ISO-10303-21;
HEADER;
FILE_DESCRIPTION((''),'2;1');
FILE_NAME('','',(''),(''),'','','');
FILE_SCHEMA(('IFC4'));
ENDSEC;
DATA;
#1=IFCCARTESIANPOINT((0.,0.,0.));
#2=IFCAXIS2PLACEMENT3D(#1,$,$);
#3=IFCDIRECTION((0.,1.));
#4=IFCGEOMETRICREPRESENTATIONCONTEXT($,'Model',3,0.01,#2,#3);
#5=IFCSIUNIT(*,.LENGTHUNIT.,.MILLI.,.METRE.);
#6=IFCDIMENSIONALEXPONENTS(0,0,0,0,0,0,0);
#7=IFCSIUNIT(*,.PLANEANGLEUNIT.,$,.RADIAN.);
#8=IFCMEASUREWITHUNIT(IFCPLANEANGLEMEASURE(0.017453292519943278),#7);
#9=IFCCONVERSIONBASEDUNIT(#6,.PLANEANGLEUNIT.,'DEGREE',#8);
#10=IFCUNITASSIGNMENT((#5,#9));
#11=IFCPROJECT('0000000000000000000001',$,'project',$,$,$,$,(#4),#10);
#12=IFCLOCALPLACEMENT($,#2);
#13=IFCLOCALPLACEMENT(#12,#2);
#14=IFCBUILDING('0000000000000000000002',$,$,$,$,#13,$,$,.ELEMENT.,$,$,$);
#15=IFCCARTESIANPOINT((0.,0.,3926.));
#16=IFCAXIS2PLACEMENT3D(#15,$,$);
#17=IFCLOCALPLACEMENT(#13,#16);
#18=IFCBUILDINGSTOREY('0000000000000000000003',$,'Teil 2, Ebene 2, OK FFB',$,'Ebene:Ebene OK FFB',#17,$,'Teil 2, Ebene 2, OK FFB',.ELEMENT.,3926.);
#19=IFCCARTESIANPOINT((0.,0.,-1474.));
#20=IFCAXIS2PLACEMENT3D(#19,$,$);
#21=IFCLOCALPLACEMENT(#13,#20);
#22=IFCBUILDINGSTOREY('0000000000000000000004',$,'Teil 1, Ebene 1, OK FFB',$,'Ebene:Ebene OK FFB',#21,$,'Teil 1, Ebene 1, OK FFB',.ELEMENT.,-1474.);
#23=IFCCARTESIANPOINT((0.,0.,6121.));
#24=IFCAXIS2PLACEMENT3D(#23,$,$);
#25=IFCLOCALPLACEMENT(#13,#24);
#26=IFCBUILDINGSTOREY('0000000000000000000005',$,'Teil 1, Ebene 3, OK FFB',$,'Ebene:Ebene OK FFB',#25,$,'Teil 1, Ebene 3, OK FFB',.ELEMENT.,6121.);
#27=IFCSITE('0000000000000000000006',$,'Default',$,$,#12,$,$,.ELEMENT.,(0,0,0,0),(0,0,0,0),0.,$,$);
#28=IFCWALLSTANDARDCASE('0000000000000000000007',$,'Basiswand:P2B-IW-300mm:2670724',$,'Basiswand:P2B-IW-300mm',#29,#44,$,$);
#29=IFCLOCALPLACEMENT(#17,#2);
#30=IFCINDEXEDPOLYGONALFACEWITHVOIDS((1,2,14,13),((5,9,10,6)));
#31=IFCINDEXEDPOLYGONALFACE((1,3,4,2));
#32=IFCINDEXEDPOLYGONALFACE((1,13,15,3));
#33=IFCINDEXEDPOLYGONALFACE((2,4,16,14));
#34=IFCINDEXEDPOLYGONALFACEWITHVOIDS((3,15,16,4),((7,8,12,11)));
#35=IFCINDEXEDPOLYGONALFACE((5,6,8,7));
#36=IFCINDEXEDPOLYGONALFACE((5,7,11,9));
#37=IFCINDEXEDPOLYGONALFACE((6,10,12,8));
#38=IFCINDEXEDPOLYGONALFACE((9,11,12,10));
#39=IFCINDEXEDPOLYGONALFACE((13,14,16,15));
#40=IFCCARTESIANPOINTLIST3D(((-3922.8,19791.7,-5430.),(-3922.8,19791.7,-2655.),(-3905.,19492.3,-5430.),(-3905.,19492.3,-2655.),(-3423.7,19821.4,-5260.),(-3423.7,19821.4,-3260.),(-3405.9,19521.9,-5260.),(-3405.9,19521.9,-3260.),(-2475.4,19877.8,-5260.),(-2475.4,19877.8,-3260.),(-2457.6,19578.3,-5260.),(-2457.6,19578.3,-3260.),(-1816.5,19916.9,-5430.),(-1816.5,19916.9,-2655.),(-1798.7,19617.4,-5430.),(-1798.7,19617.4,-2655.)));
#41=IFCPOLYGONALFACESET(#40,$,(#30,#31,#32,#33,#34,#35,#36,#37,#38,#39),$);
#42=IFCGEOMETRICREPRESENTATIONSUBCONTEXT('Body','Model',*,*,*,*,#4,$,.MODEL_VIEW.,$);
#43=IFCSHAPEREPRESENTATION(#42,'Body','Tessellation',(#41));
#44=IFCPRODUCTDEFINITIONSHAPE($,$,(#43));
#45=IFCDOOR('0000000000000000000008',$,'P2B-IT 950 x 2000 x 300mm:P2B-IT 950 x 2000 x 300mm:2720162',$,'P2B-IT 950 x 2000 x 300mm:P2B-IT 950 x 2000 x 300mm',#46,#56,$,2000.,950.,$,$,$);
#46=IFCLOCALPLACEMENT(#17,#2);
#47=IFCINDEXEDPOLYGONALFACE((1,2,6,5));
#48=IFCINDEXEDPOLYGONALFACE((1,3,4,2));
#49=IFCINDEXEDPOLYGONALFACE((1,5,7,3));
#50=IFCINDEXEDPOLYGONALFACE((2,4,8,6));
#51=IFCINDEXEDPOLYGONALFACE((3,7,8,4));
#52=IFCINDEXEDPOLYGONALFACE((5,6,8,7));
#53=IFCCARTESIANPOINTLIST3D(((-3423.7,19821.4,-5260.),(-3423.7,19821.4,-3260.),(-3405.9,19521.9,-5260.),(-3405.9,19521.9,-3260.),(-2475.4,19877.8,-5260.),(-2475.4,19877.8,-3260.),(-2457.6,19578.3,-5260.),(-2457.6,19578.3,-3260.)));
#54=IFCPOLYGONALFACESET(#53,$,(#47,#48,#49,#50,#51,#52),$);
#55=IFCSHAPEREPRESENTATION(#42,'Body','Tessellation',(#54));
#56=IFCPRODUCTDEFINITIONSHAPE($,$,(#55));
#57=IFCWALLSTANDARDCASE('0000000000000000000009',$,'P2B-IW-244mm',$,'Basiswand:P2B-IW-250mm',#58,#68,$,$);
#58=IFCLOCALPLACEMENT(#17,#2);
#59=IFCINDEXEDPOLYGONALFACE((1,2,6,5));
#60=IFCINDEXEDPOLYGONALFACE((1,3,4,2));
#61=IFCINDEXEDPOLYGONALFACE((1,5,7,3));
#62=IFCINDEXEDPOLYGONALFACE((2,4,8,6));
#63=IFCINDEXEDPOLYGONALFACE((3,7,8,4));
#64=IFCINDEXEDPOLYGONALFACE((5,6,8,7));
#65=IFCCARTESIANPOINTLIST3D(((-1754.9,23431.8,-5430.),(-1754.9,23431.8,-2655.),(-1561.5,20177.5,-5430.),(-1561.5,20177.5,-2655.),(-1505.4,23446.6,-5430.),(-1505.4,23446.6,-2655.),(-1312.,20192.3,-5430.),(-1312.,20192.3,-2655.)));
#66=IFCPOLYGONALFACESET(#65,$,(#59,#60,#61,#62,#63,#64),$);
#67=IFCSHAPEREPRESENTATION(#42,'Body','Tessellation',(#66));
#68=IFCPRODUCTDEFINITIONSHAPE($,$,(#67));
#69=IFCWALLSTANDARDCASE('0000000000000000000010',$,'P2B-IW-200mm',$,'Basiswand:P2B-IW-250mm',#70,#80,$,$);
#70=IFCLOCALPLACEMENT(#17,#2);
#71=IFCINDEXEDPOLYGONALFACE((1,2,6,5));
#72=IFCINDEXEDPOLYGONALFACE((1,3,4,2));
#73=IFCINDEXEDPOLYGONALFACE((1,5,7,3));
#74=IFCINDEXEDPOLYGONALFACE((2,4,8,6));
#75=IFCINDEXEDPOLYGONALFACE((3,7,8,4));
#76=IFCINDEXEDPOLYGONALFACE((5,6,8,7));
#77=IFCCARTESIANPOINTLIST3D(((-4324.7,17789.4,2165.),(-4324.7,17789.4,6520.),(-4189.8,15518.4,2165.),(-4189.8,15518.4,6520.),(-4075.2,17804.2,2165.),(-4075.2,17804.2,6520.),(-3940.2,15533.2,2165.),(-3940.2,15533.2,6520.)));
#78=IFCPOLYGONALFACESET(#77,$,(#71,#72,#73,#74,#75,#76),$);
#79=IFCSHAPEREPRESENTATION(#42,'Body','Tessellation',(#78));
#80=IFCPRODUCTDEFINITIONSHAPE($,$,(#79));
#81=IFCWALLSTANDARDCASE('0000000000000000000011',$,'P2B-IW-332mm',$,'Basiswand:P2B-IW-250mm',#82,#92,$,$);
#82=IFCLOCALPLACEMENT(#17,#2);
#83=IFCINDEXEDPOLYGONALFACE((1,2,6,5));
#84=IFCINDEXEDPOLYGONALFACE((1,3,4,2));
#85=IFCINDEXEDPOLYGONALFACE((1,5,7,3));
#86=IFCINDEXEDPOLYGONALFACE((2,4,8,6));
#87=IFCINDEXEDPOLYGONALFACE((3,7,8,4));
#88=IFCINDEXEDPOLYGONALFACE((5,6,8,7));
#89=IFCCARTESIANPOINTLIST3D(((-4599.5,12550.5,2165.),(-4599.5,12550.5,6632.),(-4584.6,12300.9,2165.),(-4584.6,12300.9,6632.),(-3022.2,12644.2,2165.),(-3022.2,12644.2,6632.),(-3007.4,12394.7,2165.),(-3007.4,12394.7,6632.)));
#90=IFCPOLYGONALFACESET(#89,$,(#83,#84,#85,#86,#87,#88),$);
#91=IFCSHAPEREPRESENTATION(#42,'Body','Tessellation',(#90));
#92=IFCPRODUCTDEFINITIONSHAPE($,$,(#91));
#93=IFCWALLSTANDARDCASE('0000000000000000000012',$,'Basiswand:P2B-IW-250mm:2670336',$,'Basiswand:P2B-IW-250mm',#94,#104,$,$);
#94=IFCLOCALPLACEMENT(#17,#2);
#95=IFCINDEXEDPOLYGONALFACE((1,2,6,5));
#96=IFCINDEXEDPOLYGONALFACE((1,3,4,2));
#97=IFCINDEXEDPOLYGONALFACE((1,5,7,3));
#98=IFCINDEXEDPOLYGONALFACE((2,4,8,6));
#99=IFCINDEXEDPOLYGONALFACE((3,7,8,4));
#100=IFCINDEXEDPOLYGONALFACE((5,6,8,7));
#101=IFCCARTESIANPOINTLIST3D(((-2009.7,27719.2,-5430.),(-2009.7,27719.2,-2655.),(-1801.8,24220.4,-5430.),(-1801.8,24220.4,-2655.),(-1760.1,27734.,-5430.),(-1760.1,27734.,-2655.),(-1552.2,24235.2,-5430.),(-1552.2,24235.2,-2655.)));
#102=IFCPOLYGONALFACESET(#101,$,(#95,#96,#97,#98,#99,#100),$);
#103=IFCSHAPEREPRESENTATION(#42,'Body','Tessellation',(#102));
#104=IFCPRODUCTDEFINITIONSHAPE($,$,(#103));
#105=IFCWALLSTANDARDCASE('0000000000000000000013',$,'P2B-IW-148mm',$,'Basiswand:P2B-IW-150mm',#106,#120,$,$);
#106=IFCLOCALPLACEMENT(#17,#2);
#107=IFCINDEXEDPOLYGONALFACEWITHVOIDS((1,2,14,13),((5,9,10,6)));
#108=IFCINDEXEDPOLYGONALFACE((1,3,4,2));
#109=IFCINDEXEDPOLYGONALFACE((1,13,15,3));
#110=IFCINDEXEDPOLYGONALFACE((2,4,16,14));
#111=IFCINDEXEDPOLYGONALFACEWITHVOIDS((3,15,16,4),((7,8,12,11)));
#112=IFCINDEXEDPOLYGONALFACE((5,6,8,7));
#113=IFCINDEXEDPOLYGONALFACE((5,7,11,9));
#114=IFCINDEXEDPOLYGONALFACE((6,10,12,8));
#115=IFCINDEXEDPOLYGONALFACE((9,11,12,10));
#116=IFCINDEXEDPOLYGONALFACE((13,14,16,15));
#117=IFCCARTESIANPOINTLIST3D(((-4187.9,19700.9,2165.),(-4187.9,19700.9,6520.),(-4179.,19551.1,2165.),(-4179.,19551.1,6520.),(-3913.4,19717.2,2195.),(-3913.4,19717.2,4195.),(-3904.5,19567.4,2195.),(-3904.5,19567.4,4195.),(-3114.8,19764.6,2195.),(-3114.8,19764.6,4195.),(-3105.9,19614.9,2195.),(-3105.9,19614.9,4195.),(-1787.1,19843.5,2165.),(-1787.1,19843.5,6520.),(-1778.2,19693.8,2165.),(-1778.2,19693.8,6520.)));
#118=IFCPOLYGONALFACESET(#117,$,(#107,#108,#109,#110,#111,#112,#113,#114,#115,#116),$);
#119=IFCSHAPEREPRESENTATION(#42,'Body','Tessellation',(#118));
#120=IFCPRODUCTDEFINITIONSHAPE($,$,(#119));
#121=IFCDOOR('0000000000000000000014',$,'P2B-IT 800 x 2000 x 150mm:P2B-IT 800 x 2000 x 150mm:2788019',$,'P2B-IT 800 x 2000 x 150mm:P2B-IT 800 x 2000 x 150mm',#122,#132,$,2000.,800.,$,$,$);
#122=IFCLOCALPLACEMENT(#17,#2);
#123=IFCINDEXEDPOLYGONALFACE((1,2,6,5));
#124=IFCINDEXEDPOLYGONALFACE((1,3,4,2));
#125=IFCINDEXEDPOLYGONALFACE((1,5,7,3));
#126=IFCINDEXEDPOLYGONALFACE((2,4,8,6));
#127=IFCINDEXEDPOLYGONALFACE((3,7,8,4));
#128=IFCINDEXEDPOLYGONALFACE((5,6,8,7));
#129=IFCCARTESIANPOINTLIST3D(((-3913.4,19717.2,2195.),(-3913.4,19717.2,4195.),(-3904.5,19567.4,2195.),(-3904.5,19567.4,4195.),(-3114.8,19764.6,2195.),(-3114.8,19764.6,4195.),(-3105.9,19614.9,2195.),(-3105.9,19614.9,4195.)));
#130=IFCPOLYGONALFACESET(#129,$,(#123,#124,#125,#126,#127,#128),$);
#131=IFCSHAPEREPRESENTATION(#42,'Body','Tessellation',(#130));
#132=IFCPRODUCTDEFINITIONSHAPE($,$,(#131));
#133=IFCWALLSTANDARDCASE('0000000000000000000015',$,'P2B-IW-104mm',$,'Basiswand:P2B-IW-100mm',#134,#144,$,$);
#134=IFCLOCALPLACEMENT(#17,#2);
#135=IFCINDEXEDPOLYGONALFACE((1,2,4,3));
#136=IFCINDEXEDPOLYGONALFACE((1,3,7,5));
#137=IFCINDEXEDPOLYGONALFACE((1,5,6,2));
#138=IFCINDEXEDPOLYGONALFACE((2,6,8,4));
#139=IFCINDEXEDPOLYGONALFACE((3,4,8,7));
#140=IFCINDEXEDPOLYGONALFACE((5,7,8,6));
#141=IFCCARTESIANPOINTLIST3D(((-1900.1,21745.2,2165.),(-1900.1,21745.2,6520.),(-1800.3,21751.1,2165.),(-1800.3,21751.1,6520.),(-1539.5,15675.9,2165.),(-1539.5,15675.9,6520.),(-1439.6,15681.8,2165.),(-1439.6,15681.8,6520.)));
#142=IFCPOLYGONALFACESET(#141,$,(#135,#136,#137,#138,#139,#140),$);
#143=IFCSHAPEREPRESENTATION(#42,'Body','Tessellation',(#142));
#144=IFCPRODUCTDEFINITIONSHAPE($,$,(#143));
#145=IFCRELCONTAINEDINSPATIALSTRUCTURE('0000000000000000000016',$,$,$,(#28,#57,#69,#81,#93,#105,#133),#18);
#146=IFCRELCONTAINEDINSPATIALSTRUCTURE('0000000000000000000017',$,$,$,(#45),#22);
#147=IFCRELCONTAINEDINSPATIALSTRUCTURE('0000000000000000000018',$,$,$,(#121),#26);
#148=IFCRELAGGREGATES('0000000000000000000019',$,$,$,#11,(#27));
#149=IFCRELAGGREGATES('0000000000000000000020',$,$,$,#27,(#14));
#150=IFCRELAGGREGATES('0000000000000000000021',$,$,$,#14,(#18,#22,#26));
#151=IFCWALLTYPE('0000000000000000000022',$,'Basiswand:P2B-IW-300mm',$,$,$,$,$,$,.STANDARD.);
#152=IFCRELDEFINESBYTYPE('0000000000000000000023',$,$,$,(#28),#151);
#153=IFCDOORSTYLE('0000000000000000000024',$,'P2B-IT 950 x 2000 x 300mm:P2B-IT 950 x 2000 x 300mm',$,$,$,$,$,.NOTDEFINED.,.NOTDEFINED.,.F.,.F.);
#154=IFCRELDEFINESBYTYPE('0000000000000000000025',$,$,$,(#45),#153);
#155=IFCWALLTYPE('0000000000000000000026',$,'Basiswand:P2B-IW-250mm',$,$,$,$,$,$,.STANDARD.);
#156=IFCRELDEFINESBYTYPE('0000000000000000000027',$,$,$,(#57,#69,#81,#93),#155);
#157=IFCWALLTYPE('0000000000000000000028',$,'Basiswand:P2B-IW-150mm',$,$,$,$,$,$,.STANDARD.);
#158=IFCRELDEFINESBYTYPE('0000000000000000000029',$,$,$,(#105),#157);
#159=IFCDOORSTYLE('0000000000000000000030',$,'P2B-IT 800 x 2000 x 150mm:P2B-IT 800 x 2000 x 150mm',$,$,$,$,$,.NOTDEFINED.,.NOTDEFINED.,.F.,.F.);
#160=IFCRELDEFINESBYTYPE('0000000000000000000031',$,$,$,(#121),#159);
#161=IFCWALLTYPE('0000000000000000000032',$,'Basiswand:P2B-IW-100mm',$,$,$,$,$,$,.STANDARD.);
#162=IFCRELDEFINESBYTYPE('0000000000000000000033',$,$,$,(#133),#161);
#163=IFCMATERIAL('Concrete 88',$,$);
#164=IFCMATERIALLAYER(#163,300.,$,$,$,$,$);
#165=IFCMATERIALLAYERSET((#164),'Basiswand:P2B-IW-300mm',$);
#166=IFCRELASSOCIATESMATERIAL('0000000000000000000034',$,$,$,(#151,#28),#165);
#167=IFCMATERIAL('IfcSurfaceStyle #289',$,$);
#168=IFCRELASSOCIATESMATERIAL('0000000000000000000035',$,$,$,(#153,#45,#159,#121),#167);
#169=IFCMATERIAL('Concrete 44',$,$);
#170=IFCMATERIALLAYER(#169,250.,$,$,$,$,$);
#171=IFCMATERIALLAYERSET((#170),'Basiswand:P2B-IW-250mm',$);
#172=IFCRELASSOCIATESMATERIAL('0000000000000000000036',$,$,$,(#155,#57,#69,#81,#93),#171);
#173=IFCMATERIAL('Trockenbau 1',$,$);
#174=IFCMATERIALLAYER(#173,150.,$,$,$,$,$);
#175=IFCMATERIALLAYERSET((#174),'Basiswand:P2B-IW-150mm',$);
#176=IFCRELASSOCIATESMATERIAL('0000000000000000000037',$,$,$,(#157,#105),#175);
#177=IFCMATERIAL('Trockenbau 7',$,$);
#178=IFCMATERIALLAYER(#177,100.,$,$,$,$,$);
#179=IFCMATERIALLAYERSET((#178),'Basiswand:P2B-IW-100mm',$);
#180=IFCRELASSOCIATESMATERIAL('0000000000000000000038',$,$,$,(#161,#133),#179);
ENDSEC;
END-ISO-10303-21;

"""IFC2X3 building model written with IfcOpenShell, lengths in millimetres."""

from ifc_helpers import new_model, entity, si_unit, converted_unit, direction, frame, frame_2d, origin, origin_2d_with_axis, place, context, subcontext, project, spatial, rectangle, extrude, source, transform, mapped, material, layer, layer_set, layer_usage, type_object, type_shapes, element, fill, save


model = new_model("IFC2X3")

# Units and contexts
model_context = context("Model", 3, precision=0.01, world=origin(), true_north=direction((0.0, 1.0)))
body_context = subcontext(model_context, "Body", "Model", "MODEL_VIEW")
ifc_project = project(units=[si_unit("LENGTHUNIT", "METRE", prefix="MILLI"), converted_unit("PLANEANGLEUNIT", "DEGREE", entity("IfcPlaneAngleMeasure", 0.017453292519943278), si_unit("PLANEANGLEUNIT", "RADIAN"), dimensions=[0, 0, 0, 0, 0, 0, 0])], contexts=[model_context])

# Site, building, storey
site_placement = place(None, origin())
site = spatial("IfcSite", under=ifc_project, at=site_placement, Name="Default", CompositionType="ELEMENT", RefLatitude=(0, 0, 0, 0), RefLongitude=(0, 0, 0, 0), RefElevation=0.0)
building_placement = place(site_placement, origin())
building = spatial("IfcBuilding", under=site, at=building_placement, CompositionType="ELEMENT")
storey_1_placement = place(building_placement, frame((0.0, 0.0, 3926.0)))
storey_1 = spatial("IfcBuildingStorey", under=building, at=storey_1_placement, Name="Teil 2, Ebene 2, OK FFB", ObjectType="Ebene:Ebene OK FFB", LongName="Teil 2, Ebene 2, OK FFB", CompositionType="ELEMENT", Elevation=3926.0)

# Wall, opening
ifc_material_1 = material(Name="Concrete 88")
ifc_layer_1 = layer(ifc_material_1, 300.0)
ifc_layer_set_1 = layer_set([ifc_layer_1], Name="Basiswand:P2B-IW-300mm")
ifc_layer_usage_1 = layer_usage(ifc_layer_set_1, "AXIS2", "NEGATIVE", 150.0)
wall_type_1 = type_object("IfcWallType", Name="Basiswand:P2B-IW-300mm", PredefinedType="STANDARD", material=ifc_layer_set_1)
wall_1_placement = place(storey_1_placement, frame((-1807.6, 19767.2, -5430.0), z_axis=(0.0, 0.0, 1.0), x_axis=(-0.998239, -0.059319, 0.0)))
wall_1 = element("IfcWallStandardCase", 1, at=wall_1_placement, inside=storey_1, type_object=wall_type_1, material=ifc_layer_usage_1, Name="Basiswand:P2B-IW-300mm:2670724", ObjectType="Basiswand:P2B-IW-300mm", context=body_context, shape_type="SweptSolid", body=[
    extrude(rectangle(XDim=2110.0, YDim=300.0, at=frame_2d((1055.0, 0.0), x_axis=(-1.0, 0.0))), origin(), (0.0, 0.0, 1.0), 2775.0),
])
opening_1_placement = place(wall_1_placement, frame((-631.9, 19839.6, 30.0), z_axis=(0.0, 0.0, 1.0), x_axis=(-0.998239, 0.059319, 0.0)))
opening_1 = element("IfcOpeningElement", 2, at=opening_1_placement, cuts=wall_1, ObjectType="Opening", context=body_context, shape_type="SweptSolid", body=[
    extrude(rectangle(XDim=2000.0, YDim=950.0, at=frame_2d((0.0, 0.0), x_axis=(1.0, 0.0))), frame((-2949.5, 19849.6, 1140.0), z_axis=(0.059319, -0.998239, 0.0), x_axis=(0.0, 0.0, -1.0)), (0.0, 0.0, 1.0), 300.0),
])

# Shared definitions
storey_2_placement = place(building_placement, frame((0.0, 0.0, -1474.0)))
storey_2 = spatial("IfcBuildingStorey", under=building, at=storey_2_placement, Name="Teil 1, Ebene 1, OK FFB", ObjectType="Ebene:Ebene OK FFB", LongName="Teil 1, Ebene 1, OK FFB", CompositionType="ELEMENT", Elevation=-1474.0)

# Door
ifc_material_2 = material(Name="IfcSurfaceStyle #289")
door_style_1 = type_object("IfcDoorStyle", Name="P2B-IT 950 x 2000 x 300mm:P2B-IT 950 x 2000 x 300mm", ConstructionType="NOTDEFINED", OperationType="NOTDEFINED", ParameterTakesPrecedence=False, Sizeable=False, material=ifc_material_2)
shared_shape_1 = source(origin(), body_context, "Body", "SweptSolid", [
    extrude(rectangle(XDim=300.0, YDim=950.0, at=frame_2d((0.0, 0.0), x_axis=(1.0, 0.0))), frame((475.0, 150.0, 0.0), z_axis=(0.0, 0.0, 1.0), x_axis=(0.0, 1.0, 0.0)), (0.0, 0.0, 1.0), 2000.0),
])
type_shapes(door_style_1, [shared_shape_1])
door_1_placement = place(opening_1_placement, frame((-3405.9, 19521.9, 140.0), z_axis=(0.0, 0.0, 1.0), x_axis=(0.998239, 0.059319, 0.0)))
door_1 = element("IfcDoor", 3, at=door_1_placement, inside=storey_2, type_object=door_style_1, material=ifc_material_2, Name="P2B-IT 950 x 2000 x 300mm:P2B-IT 950 x 2000 x 300mm:2720162", ObjectType="P2B-IT 950 x 2000 x 300mm:P2B-IT 950 x 2000 x 300mm", OverallHeight=2000.0, OverallWidth=950.0, context=body_context, shape_type="MappedRepresentation", body=[
    mapped(shared_shape_1, transform((0.0, 0.0, 0.0), scale=1.0)),
])
fill(opening_1, door_1)

# Wall
ifc_material_3 = material(Name="Concrete 44")
ifc_layer_2 = layer(ifc_material_3, 250.0)
ifc_layer_set_2 = layer_set([ifc_layer_2], Name="Basiswand:P2B-IW-250mm")
ifc_layer_usage_2 = layer_usage(ifc_layer_set_2, "AXIS2", "NEGATIVE", 125.0)
wall_type_2 = type_object("IfcWallType", Name="Basiswand:P2B-IW-250mm", PredefinedType="STANDARD", material=ifc_layer_set_2)
wall_2_placement = place(storey_1_placement, frame((-1436.8, 20184.9, -5430.0), z_axis=(0.0, 0.0, 1.0), x_axis=(-0.059319, 0.998239, 0.0)))
element("IfcWallStandardCase", 4, at=wall_2_placement, inside=storey_1, type_object=wall_type_2, material=ifc_layer_usage_2, Name="P2B-IW-244mm", ObjectType="Basiswand:P2B-IW-250mm", context=body_context, shape_type="SweptSolid", body=[
    extrude(rectangle(XDim=3260.0, YDim=250.0, at=frame_2d((1630.0, 0.0), x_axis=(-1.0, 0.0))), origin(), (0.0, 0.0, 1.0), 2775.0),
])

# Walls
ifc_layer_usage_3 = layer_usage(ifc_layer_set_2, "AXIS2", "POSITIVE", -125.0)
wall_3_placement = place(storey_1_placement, frame((-4065.0, 15525.8, 2165.0), z_axis=(0.0, 0.0, 1.0), x_axis=(-0.059319, 0.998239, 0.0)))
element("IfcWallStandardCase", 5, at=wall_3_placement, inside=storey_1, type_object=wall_type_2, material=ifc_layer_usage_3, Name="P2B-IW-200mm", ObjectType="Basiswand:P2B-IW-250mm", context=body_context, shape_type="SweptSolid", body=[
    extrude(rectangle(XDim=2275.0, YDim=250.0, at=frame_2d((1137.5, 0.0), x_axis=(-1.0, 0.0))), origin(), (0.0, 0.0, 1.0), 4355.0),
])
ifc_layer_usage_4 = layer_usage(ifc_layer_set_2, "AXIS2", "POSITIVE", -125.0)
wall_4_placement = place(storey_1_placement, frame((-3014.8, 12519.5, 2165.0), z_axis=(0.0, 0.0, 1.0), x_axis=(-0.998239, -0.059319, 0.0)))
element("IfcWallStandardCase", 6, at=wall_4_placement, inside=storey_1, type_object=wall_type_2, material=ifc_layer_usage_4, Name="P2B-IW-332mm", ObjectType="Basiswand:P2B-IW-250mm", context=body_context, shape_type="SweptSolid", body=[
    extrude(rectangle(XDim=1580.0, YDim=250.0, at=frame_2d((790.0, 0.0), x_axis=(-1.0, 0.0))), origin(), (0.0, 0.0, 1.0), 4467.0),
])
ifc_layer_usage_5 = layer_usage(ifc_layer_set_2, "AXIS2", "NEGATIVE", 125.0)
wall_5_placement = place(storey_1_placement, frame((-1677.0, 24227.8, -5430.0), z_axis=(0.0, 0.0, 1.0), x_axis=(-0.059319, 0.998239, 0.0)))
element("IfcWallStandardCase", 7, at=wall_5_placement, inside=storey_1, type_object=wall_type_2, material=ifc_layer_usage_5, Name="Basiswand:P2B-IW-250mm:2670336", ObjectType="Basiswand:P2B-IW-250mm", context=body_context, shape_type="SweptSolid", body=[
    extrude(rectangle(XDim=3505.0, YDim=250.0, at=frame_2d((1752.5, 0.0), x_axis=(-1.0, 0.0))), origin(), (0.0, 0.0, 1.0), 2775.0),
])

# Wall, opening
ifc_material_4 = material(Name="Trockenbau 1")
ifc_layer_3 = layer(ifc_material_4, 150.0)
ifc_layer_set_3 = layer_set([ifc_layer_3], Name="Basiswand:P2B-IW-150mm")
ifc_layer_usage_6 = layer_usage(ifc_layer_set_3, "AXIS2", "POSITIVE", -75.0)
wall_type_3 = type_object("IfcWallType", Name="Basiswand:P2B-IW-150mm", PredefinedType="STANDARD", material=ifc_layer_set_3)
wall_6_placement = place(storey_1_placement, frame((-1782.7, 19768.7, 2165.0), z_axis=(0.0, 0.0, 1.0), x_axis=(-0.998239, -0.059319, 0.0)))
wall_6 = element("IfcWallStandardCase", 8, at=wall_6_placement, inside=storey_1, type_object=wall_type_3, material=ifc_layer_usage_6, Name="P2B-IW-148mm", ObjectType="Basiswand:P2B-IW-150mm", context=body_context, shape_type="SweptSolid", body=[
    extrude(rectangle(XDim=2405.0, YDim=150.0, at=frame_2d((1202.5, 0.0), x_axis=(-1.0, 0.0))), origin(), (0.0, 0.0, 1.0), 4355.0),
])
opening_2_placement = place(wall_6_placement, frame((-606.9, 19839.6, 30.0), z_axis=(0.0, 0.0, 1.0), x_axis=(-0.998239, 0.059319, 0.0)))
opening_2 = element("IfcOpeningElement", 9, at=opening_2_placement, cuts=wall_6, ObjectType="Opening", context=body_context, shape_type="SweptSolid", body=[
    extrude(rectangle(XDim=2000.0, YDim=800.0, at=frame_2d((0.0, 0.0), x_axis=(1.0, 0.0))), frame((-3520.0, 19840.7, 1000.0), z_axis=(0.059319, -0.998239, 0.0), x_axis=(0.0, 0.0, -1.0)), (0.0, 0.0, 1.0), 350.0),
])

# Shared definitions
storey_3_placement = place(building_placement, frame((0.0, 0.0, 6121.0)))
storey_3 = spatial("IfcBuildingStorey", under=building, at=storey_3_placement, Name="Teil 1, Ebene 3, OK FFB", ObjectType="Ebene:Ebene OK FFB", LongName="Teil 1, Ebene 3, OK FFB", CompositionType="ELEMENT", Elevation=6121.0)

# Door
door_style_2 = type_object("IfcDoorStyle", Name="P2B-IT 800 x 2000 x 150mm:P2B-IT 800 x 2000 x 150mm", ConstructionType="NOTDEFINED", OperationType="NOTDEFINED", ParameterTakesPrecedence=False, Sizeable=False, material=ifc_material_2)
shared_shape_2 = source(origin(), body_context, "Body", "SweptSolid", [
    extrude(rectangle(XDim=150.0, YDim=800.0, at=origin_2d_with_axis()), frame((400.0, 175.0, 0.0), z_axis=(0.0, 0.0, 1.0), x_axis=(0.0, 1.0, 0.0)), (0.0, 0.0, 1.0), 2000.0),
])
type_shapes(door_style_2, [shared_shape_2])
door_2_placement = place(opening_2_placement, frame((-3898.5, 19467.6, 0.0), z_axis=(0.0, 0.0, 1.0), x_axis=(0.998239, 0.059319, 0.0)))
door_2 = element("IfcDoor", 10, at=door_2_placement, inside=storey_3, type_object=door_style_2, material=ifc_material_2, Name="P2B-IT 800 x 2000 x 150mm:P2B-IT 800 x 2000 x 150mm:2788019", ObjectType="P2B-IT 800 x 2000 x 150mm:P2B-IT 800 x 2000 x 150mm", OverallHeight=2000.0, OverallWidth=800.0, context=body_context, shape_type="MappedRepresentation", body=[
    mapped(shared_shape_2, transform((0.0, 0.0, 0.0), scale=1.0)),
])
fill(opening_2, door_2)

# Wall
ifc_material_5 = material(Name="Trockenbau 7")
ifc_layer_4 = layer(ifc_material_5, 100.0)
ifc_layer_set_4 = layer_set([ifc_layer_4], Name="Basiswand:P2B-IW-100mm")
ifc_layer_usage_7 = layer_usage(ifc_layer_set_4, "AXIS2", "NEGATIVE", 50.0)
wall_type_4 = type_object("IfcWallType", Name="Basiswand:P2B-IW-100mm", PredefinedType="STANDARD", material=ifc_layer_set_4)
wall_7_placement = place(storey_1_placement, frame((-1489.5, 15678.8, 2165.0), z_axis=(0.0, 0.0, 1.0), x_axis=(-0.059319, 0.998239, 0.0)))
element("IfcWallStandardCase", 11, at=wall_7_placement, inside=storey_1, type_object=wall_type_4, material=ifc_layer_usage_7, Name="P2B-IW-104mm", ObjectType="Basiswand:P2B-IW-100mm", context=body_context, shape_type="SweptSolid", body=[
    extrude(rectangle(XDim=6080.0, YDim=100.0, at=frame_2d((3040.0, 0.0), x_axis=(-1.0, 0.0))), origin(), (0.0, 0.0, 1.0), 4355.0),
])

save(model, "model.ifc")
